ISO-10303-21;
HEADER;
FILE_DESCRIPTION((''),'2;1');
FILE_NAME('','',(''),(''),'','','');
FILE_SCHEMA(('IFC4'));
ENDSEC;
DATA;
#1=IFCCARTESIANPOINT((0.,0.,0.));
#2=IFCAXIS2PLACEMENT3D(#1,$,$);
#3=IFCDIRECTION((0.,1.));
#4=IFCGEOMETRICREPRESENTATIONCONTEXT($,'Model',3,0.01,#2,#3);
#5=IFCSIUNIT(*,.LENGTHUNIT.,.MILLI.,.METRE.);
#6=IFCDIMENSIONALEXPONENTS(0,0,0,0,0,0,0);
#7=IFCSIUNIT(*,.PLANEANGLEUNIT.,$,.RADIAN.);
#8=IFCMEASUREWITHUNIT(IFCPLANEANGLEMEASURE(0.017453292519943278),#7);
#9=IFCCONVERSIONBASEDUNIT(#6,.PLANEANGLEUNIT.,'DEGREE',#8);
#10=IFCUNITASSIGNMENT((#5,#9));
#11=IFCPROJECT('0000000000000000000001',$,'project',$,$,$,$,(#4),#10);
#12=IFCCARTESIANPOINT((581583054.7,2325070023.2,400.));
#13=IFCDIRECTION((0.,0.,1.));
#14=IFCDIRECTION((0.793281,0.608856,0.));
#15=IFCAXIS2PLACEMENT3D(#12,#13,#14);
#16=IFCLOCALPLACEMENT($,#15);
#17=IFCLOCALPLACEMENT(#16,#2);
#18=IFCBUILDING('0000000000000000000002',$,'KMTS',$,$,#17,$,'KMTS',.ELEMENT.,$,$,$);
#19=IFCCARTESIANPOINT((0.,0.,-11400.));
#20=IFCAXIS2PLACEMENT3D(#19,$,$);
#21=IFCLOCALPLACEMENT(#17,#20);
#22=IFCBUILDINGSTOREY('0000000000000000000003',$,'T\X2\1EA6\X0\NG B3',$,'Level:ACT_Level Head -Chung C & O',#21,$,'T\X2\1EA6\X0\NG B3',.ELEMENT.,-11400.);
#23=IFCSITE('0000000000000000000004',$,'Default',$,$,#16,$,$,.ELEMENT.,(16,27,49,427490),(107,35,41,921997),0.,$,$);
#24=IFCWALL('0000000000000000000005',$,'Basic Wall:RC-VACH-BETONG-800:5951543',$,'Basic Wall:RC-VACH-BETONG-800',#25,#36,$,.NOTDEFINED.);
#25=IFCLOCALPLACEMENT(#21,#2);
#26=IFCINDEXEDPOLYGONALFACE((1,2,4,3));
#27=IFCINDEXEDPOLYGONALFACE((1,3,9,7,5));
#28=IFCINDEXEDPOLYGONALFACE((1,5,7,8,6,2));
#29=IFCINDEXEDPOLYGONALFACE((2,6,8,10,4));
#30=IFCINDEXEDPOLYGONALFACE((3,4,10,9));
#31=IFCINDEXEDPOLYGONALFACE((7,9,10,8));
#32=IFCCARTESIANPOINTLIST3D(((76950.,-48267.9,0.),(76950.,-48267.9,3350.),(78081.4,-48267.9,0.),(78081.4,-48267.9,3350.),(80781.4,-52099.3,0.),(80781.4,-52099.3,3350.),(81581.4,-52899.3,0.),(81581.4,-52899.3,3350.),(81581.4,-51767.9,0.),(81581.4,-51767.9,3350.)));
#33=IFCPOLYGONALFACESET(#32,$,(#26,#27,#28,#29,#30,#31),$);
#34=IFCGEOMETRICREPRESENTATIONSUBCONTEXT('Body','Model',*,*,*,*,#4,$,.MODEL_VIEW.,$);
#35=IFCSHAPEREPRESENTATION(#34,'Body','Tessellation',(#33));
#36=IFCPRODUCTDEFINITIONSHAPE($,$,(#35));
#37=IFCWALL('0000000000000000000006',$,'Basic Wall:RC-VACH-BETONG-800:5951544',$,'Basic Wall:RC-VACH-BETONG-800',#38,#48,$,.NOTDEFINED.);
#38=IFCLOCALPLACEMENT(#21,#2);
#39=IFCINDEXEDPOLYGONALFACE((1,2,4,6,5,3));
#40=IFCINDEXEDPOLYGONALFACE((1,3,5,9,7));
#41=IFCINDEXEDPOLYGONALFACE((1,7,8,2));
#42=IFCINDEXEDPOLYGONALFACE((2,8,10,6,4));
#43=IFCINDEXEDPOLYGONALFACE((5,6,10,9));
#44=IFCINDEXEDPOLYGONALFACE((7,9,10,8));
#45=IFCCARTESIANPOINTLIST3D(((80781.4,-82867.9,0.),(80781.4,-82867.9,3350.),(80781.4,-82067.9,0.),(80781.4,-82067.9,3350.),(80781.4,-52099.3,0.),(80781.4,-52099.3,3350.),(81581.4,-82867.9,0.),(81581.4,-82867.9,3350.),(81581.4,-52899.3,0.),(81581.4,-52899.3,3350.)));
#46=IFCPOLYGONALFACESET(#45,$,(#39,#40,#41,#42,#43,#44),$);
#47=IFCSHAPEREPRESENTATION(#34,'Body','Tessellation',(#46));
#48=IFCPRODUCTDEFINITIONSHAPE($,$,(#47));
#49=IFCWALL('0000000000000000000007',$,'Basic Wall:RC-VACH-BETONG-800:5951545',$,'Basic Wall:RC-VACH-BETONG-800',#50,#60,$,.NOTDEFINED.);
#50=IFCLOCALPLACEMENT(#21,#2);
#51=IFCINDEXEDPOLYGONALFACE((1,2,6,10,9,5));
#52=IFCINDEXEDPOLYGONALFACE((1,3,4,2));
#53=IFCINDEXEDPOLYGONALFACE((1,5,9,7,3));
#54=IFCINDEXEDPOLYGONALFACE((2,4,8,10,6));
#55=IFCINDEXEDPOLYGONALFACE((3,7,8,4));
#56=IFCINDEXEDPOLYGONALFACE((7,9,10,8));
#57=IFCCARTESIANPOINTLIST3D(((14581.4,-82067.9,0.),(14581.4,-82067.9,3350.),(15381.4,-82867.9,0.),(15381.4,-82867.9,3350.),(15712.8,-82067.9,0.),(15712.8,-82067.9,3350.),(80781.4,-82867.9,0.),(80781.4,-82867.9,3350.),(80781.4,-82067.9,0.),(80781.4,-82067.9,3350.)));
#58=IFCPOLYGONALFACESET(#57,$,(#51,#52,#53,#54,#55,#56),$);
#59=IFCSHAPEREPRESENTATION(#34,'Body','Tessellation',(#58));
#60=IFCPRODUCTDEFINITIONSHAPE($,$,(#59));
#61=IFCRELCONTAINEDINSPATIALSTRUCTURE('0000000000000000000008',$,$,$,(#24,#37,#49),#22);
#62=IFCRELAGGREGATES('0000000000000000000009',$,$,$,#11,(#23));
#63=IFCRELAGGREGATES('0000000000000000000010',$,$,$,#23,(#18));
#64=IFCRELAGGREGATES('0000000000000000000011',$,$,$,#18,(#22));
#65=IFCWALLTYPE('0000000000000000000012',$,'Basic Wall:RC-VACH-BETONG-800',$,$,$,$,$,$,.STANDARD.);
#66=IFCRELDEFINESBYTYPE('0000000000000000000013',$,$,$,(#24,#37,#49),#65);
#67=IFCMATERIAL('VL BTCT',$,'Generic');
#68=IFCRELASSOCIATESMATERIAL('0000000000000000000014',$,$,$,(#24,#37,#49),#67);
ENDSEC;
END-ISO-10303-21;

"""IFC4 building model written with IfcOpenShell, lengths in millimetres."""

from ifc_helpers import new_model, entity, si_unit, converted_unit, direction, frame, origin, place, context, subcontext, project, spatial, indexed_curve, outline, extrude, material, type_object, element, save


model = new_model("IFC4")

# Units and contexts
model_context = context("Model", 3, precision=0.01, world=origin(), true_north=direction((0.0, 1.0)))
body_context = subcontext(model_context, "Body", "Model", "MODEL_VIEW")
ifc_project = project(units=[si_unit("LENGTHUNIT", "METRE", prefix="MILLI"), converted_unit("PLANEANGLEUNIT", "DEGREE", entity("IfcPlaneAngleMeasure", 0.017453292519943278), si_unit("PLANEANGLEUNIT", "RADIAN"), dimensions=[0, 0, 0, 0, 0, 0, 0])], contexts=[model_context])

# Site, building, storey
site_placement = place(None, frame((581583054.7, 2325070023.2, 400.0), z_axis=(0.0, 0.0, 1.0), x_axis=(0.793281, 0.608856, 0.0)))
site = spatial("IfcSite", under=ifc_project, at=site_placement, Name="Default", CompositionType="ELEMENT", RefLatitude=(16, 27, 49, 427490), RefLongitude=(107, 35, 41, 921997), RefElevation=0.0)
building_placement = place(site_placement, origin())
building = spatial("IfcBuilding", under=site, at=building_placement, Name="KMTS", LongName="KMTS", CompositionType="ELEMENT")
storey_placement = place(building_placement, frame((0.0, 0.0, -11400.0)))
storey = spatial("IfcBuildingStorey", under=building, at=storey_placement, Name="TẦNG B3", ObjectType="Level:ACT_Level Head -Chung C & O", LongName="TẦNG B3", CompositionType="ELEMENT", Elevation=-11400.0)

# Shared definitions
ifc_material = material(Name="VL BTCT", Category="Generic")

# Walls
wall_type_1 = type_object("IfcWallType", Name="Basic Wall:RC-VACH-BETONG-800", PredefinedType="STANDARD")
wall_1_placement = place(storey_placement, frame((77232.9, -47985.1, 0.0), z_axis=(0.0, 0.0, 1.0), x_axis=(0.707107, -0.707107, 0.0)))
element("IfcWall", 1, at=wall_1_placement, inside=storey, type_object=wall_type_1, material=ifc_material, Name="Basic Wall:RC-VACH-BETONG-800:5951543", ObjectType="Basic Wall:RC-VACH-BETONG-800", PredefinedType="NOTDEFINED", context=body_context, shape_type="SweptSolid", body=[
    extrude(outline(indexed_curve([(6549.7, -400.0), (5749.7, 400.0), (800.0, 400.0), (0.0, -400.0), (5418.4, -400.0), (6549.7, -400.0)], self_intersect=False)), origin(), (0.0, 0.0, 1.0), 3350.0),
])
wall_2_placement = place(storey_placement, frame((81181.4, -52099.3, 0.0), z_axis=(0.0, 0.0, 1.0), x_axis=(0.0, -1.0, 0.0)))
element("IfcWall", 2, at=wall_2_placement, inside=storey, type_object=wall_type_1, material=ifc_material, Name="Basic Wall:RC-VACH-BETONG-800:5951544", ObjectType="Basic Wall:RC-VACH-BETONG-800", PredefinedType="NOTDEFINED", context=body_context, shape_type="SweptSolid", body=[
    extrude(outline(indexed_curve([(30768.6, -400.0), (30768.6, 400.0), (800.0, 400.0), (0.0, -400.0), (29968.6, -400.0), (30768.6, -400.0)], self_intersect=False)), origin(), (0.0, 0.0, 1.0), 3350.0),
])
wall_3_placement = place(storey_placement, frame((80781.4, -82467.9, 0.0), z_axis=(0.0, 0.0, 1.0), x_axis=(-1.0, 0.0, 0.0)))
element("IfcWall", 3, at=wall_3_placement, inside=storey, type_object=wall_type_1, material=ifc_material, Name="Basic Wall:RC-VACH-BETONG-800:5951545", ObjectType="Basic Wall:RC-VACH-BETONG-800", PredefinedType="NOTDEFINED", context=body_context, shape_type="SweptSolid", body=[
    extrude(outline(indexed_curve([(66200.0, -400.0), (65400.0, 400.0), (0.0, 400.0), (0.0, -400.0), (65068.6, -400.0), (66200.0, -400.0)], self_intersect=False)), origin(), (0.0, 0.0, 1.0), 3350.0),
])

save(model, "model.ifc")
